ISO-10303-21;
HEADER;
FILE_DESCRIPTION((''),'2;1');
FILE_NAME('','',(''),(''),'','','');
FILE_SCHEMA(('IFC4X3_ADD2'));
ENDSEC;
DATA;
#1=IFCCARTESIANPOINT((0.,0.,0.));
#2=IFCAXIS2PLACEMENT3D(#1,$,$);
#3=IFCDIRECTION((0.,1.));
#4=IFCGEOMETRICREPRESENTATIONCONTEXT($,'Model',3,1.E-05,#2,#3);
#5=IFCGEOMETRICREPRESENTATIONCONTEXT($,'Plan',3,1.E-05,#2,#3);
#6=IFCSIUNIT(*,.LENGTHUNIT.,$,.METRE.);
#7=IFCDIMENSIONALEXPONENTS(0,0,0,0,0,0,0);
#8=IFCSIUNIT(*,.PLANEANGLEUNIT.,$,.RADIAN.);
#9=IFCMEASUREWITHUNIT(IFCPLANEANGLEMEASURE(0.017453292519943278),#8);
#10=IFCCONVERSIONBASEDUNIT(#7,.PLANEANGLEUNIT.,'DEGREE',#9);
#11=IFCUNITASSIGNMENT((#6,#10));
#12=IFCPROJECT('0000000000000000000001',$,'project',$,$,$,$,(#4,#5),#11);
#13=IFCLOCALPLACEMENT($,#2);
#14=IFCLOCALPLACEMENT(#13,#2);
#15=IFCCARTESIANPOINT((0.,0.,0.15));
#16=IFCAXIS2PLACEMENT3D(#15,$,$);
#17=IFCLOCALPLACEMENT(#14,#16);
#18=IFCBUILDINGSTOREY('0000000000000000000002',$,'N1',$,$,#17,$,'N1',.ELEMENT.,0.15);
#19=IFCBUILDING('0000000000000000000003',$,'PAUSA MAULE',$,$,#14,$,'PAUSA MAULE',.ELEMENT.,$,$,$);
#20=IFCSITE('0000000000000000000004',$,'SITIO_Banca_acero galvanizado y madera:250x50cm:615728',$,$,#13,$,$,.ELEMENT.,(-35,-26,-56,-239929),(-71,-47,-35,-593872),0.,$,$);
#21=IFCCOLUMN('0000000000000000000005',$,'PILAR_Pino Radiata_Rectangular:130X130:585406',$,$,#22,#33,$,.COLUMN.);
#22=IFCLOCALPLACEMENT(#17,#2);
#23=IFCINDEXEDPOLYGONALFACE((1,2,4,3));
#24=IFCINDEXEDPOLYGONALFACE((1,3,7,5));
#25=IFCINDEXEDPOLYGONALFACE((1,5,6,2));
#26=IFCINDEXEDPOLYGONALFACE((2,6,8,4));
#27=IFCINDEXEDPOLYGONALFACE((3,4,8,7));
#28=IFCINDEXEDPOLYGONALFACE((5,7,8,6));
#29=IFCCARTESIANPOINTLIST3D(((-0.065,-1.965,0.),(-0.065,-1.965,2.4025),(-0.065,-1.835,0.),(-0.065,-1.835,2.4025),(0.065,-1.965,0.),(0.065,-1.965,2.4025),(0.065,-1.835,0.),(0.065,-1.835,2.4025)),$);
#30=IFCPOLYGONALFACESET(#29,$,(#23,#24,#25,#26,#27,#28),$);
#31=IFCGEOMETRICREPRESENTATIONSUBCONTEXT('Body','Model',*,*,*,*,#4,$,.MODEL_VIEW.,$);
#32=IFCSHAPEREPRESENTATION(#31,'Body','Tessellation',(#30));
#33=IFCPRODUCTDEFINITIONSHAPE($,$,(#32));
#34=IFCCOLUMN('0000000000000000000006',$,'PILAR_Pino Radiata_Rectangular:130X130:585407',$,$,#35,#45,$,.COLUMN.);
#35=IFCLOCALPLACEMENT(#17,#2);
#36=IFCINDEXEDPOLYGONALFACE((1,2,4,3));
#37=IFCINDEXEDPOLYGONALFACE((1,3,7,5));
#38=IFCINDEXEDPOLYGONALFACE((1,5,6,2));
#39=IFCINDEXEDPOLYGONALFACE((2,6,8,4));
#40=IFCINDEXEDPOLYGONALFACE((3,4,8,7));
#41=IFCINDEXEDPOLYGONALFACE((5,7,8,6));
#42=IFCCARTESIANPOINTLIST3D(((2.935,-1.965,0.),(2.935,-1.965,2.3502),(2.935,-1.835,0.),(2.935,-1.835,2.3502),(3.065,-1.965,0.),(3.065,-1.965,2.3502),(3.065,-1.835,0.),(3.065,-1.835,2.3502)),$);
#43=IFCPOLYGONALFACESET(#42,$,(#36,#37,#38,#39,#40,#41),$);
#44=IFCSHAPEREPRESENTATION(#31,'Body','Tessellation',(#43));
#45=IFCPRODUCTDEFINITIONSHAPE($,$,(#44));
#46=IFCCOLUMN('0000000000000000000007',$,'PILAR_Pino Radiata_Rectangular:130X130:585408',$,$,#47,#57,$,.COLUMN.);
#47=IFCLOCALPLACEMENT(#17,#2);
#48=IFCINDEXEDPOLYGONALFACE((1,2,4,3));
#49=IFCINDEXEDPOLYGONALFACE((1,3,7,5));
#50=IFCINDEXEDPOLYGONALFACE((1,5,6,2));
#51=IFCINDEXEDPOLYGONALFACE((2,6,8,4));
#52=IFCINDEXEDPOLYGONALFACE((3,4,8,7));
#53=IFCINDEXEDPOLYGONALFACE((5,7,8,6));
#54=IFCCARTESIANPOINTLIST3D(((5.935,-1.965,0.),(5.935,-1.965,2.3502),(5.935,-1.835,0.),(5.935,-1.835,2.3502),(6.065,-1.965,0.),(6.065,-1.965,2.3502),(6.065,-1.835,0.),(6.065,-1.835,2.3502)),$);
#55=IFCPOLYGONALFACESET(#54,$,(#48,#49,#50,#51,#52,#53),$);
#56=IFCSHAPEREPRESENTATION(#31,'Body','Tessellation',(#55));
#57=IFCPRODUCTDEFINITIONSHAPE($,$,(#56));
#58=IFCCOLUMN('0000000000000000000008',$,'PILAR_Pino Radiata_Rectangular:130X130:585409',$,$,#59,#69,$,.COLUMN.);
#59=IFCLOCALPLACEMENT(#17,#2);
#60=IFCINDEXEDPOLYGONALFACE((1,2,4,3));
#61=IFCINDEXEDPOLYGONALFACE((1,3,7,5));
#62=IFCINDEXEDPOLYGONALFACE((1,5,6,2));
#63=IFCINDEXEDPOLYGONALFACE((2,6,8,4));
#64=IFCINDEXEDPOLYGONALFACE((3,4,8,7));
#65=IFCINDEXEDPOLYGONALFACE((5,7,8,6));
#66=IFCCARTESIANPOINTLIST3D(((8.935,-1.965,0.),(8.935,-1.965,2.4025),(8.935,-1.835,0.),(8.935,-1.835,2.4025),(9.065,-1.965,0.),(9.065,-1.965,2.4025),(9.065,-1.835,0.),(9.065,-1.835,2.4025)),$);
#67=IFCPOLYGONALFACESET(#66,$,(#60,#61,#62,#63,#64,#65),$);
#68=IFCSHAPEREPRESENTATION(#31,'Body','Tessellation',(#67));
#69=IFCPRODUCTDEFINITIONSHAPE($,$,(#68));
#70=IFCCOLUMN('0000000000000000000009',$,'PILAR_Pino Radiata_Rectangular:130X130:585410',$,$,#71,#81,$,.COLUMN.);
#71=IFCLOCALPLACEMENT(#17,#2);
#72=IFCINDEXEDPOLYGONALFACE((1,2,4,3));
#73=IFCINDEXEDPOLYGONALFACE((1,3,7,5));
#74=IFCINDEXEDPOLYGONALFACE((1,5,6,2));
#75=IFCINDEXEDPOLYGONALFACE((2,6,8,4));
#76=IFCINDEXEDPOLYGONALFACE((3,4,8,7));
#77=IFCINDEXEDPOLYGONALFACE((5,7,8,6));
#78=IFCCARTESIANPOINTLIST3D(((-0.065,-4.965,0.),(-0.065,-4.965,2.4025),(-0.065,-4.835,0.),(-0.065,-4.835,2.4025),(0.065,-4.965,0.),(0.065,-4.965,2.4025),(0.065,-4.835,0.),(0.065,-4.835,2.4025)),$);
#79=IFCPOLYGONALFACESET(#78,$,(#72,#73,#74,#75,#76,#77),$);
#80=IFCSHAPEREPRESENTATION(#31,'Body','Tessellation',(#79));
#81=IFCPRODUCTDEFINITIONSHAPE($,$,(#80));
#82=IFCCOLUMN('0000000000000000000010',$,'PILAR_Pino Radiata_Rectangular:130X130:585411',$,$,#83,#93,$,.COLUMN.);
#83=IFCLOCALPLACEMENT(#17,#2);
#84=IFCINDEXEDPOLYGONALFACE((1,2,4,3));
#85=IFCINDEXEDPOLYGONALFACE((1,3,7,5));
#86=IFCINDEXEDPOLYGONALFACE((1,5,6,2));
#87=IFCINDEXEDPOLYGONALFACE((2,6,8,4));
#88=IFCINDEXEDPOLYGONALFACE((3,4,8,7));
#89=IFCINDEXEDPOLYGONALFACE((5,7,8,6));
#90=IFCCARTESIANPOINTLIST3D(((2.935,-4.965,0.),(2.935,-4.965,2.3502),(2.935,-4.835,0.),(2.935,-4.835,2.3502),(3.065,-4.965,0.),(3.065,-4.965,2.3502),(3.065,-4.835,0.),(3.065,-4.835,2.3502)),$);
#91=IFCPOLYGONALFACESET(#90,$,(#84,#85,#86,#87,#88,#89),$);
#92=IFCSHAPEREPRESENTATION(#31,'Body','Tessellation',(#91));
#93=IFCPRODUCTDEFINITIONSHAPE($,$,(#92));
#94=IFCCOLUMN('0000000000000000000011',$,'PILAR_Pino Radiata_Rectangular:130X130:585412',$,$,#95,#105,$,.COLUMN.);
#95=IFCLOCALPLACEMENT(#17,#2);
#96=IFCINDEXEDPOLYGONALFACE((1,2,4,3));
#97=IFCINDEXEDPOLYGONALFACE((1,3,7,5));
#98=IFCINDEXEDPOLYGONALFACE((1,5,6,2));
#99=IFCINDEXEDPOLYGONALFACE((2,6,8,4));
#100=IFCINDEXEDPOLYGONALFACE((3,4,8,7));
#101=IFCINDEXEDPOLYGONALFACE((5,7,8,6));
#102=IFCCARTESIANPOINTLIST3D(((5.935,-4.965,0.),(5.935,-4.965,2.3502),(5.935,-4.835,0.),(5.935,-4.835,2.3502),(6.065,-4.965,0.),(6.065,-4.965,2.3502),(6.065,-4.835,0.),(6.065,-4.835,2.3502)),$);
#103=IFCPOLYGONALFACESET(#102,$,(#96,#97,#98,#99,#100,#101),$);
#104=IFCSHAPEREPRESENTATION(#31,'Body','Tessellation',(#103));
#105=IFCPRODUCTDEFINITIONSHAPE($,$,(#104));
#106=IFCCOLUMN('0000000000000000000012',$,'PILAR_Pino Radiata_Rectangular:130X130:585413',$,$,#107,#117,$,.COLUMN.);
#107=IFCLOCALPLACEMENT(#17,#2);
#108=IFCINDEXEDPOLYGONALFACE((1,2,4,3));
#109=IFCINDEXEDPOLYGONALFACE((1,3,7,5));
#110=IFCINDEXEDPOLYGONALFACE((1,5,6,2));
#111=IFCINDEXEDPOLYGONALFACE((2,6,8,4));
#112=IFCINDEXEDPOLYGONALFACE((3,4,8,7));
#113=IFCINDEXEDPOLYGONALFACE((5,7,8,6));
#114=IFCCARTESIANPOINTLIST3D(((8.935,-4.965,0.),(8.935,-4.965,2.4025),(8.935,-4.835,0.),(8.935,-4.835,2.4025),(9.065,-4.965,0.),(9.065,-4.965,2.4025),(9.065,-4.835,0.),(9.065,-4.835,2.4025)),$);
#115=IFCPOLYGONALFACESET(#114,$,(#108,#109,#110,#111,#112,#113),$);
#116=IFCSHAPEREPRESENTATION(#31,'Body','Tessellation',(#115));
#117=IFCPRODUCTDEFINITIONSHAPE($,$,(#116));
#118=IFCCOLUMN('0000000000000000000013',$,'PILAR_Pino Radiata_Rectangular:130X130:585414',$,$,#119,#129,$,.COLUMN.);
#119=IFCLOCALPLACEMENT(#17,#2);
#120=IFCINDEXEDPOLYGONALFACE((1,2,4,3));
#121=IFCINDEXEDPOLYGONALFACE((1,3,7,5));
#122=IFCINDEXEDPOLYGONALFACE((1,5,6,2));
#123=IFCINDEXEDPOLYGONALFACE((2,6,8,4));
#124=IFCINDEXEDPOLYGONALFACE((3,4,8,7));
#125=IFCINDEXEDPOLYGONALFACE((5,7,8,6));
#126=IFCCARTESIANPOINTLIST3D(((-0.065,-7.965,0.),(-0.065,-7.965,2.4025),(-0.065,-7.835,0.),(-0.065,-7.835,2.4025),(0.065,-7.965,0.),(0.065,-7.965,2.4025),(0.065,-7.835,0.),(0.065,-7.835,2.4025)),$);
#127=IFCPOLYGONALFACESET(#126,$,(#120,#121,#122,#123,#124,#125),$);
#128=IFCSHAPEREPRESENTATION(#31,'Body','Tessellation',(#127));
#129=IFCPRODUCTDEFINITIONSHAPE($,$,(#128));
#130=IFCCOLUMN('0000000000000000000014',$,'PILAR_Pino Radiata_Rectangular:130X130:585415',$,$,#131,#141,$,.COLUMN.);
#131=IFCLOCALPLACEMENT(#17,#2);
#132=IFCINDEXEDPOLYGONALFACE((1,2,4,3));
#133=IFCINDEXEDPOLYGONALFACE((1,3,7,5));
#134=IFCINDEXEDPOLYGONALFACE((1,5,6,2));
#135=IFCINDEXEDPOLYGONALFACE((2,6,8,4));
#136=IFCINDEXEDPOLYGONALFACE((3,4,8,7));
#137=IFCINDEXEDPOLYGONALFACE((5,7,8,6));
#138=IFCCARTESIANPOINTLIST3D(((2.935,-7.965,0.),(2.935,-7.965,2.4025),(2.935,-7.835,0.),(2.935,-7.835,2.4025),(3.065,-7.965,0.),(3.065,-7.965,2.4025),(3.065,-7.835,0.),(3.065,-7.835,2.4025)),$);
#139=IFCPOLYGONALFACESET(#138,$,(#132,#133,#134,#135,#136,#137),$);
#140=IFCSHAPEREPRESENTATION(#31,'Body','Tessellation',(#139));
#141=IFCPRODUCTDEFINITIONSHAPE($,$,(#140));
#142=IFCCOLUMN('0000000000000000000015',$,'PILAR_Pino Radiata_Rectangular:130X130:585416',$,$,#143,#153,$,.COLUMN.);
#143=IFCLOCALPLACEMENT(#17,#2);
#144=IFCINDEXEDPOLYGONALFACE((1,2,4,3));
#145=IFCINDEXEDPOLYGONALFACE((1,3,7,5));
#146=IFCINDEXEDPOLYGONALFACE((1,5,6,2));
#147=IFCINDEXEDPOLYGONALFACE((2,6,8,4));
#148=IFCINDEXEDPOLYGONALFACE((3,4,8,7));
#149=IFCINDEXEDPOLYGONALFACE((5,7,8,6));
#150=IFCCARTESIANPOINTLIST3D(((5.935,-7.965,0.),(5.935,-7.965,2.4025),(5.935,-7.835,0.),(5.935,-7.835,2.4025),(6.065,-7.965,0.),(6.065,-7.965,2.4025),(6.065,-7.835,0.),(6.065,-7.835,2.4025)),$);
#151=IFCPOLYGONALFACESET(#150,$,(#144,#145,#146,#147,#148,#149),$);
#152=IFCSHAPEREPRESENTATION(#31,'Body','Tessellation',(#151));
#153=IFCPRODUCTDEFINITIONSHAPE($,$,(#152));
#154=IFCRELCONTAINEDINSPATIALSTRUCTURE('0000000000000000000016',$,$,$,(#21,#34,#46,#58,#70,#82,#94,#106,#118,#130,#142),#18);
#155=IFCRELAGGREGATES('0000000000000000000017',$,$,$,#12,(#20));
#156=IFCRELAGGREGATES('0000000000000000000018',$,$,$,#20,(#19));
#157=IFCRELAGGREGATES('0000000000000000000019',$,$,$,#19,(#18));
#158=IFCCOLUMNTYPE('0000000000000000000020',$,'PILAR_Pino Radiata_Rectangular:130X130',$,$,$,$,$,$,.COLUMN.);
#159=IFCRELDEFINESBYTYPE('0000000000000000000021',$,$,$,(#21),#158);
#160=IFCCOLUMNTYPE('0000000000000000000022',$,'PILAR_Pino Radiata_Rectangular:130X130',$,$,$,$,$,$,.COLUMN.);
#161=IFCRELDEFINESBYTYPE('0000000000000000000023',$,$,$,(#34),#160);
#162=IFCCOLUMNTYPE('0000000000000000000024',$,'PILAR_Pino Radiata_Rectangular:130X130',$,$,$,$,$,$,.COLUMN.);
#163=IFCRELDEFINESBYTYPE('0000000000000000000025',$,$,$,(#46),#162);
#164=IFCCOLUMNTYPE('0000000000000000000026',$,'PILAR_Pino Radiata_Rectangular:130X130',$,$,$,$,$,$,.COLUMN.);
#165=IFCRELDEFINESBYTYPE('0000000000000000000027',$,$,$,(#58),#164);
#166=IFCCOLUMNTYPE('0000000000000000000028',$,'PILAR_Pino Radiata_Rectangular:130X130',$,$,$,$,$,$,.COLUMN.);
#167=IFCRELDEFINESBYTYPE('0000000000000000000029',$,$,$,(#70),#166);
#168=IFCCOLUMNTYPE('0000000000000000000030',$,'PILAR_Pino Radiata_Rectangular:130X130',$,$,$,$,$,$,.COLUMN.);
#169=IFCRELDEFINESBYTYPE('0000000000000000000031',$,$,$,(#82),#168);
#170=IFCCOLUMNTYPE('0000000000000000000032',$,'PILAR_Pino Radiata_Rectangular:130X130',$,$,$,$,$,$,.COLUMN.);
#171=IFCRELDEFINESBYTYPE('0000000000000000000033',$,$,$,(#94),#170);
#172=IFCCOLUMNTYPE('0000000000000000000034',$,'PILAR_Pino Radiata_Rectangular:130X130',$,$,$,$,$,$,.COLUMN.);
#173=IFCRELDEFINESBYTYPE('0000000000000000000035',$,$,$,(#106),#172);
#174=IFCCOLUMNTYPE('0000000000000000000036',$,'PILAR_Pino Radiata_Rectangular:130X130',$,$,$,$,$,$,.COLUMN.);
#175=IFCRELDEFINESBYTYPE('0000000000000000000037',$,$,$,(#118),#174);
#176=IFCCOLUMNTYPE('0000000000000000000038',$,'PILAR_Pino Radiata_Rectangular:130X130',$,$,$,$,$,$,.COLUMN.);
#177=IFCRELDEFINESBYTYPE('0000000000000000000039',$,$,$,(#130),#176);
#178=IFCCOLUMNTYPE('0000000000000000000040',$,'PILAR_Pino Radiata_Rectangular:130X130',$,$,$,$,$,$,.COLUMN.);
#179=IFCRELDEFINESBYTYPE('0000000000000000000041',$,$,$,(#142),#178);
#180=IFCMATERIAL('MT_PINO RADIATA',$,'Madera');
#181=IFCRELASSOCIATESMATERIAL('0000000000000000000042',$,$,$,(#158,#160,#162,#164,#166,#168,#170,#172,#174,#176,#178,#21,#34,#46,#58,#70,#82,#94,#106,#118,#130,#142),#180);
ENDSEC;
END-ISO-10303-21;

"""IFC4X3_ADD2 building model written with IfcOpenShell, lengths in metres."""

from ifc_helpers import new_model, entity, si_unit, converted_unit, direction, frame, frame_2d, origin, origin_2d_with_axis, place, context, subcontext, project, spatial, rectangle, extrude, source, transform, mapped, material, material_profile, profile_set, profile_usage, type_object, type_shapes, element, save


model = new_model("IFC4X3_ADD2")

# Units and contexts
model_context = context("Model", 3, precision=1e-05, world=origin(), true_north=direction((0.0, 1.0)))
plan_context = context("Plan", 3, precision=1e-05, world=origin(), true_north=direction((0.0, 1.0)))
body_context = subcontext(model_context, "Body", "Model", "MODEL_VIEW")
ifc_project = project(units=[si_unit("LENGTHUNIT", "METRE"), converted_unit("PLANEANGLEUNIT", "DEGREE", entity("IfcPlaneAngleMeasure", 0.017453292519943278), si_unit("PLANEANGLEUNIT", "RADIAN"), dimensions=[0, 0, 0, 0, 0, 0, 0])], contexts=[model_context, plan_context])

# Site, building, storey
site_placement = place(None, origin())
site = spatial("IfcSite", under=ifc_project, at=site_placement, Name="SITIO_Banca_acero galvanizado y madera:250x50cm:615728", CompositionType="ELEMENT", RefLatitude=(-35, -26, -56, -239929), RefLongitude=(-71, -47, -35, -593872), RefElevation=0.0)
building_placement = place(site_placement, origin())
building = spatial("IfcBuilding", under=site, at=building_placement, Name="PAUSA MAULE", LongName="PAUSA MAULE", CompositionType="ELEMENT")
storey_placement = place(building_placement, frame((0.0, 0.0, 0.15)))
storey = spatial("IfcBuildingStorey", under=building, at=storey_placement, Name="N1", LongName="N1", CompositionType="ELEMENT", Elevation=0.15)

# Columns
ifc_material_1 = material(Name="MT_PINO RADIATA", Category="Madera")
ifc_material_profile = material_profile(ifc_material_1, rectangle(XDim=0.13, YDim=0.13, at=frame_2d((0.0, 0.0), x_axis=(1.0, 0.0))), Name="130X130")
ifc_profile_set = profile_set([ifc_material_profile], Name="130X130")
ifc_profile_usage = profile_usage(ifc_profile_set)
column_type_1 = type_object("IfcColumnType", Name="PILAR_Pino Radiata_Rectangular:130X130", PredefinedType="COLUMN", material=ifc_profile_set)
shared_shape_1 = source(origin(), body_context, "Body", "SweptSolid", [
    extrude(rectangle(XDim=0.13, YDim=0.13, at=frame_2d((0.0, 0.0), x_axis=(1.0, 0.0))), frame((0.0, -1.9, 0.15)), (0.0, 0.0, 1.0), 2.4025),
])
type_shapes(column_type_1, [shared_shape_1])
column_1_placement = place(storey_placement, frame((0.0, 0.0, -0.15)))
element("IfcColumn", 1, at=column_1_placement, inside=storey, type_object=column_type_1, material=ifc_profile_usage, Name="PILAR_Pino Radiata_Rectangular:130X130:585406", PredefinedType="COLUMN", context=body_context, shape_type="MappedRepresentation", body=[
    mapped(shared_shape_1, transform((0.0, 0.0, 0.0), scale=1.0)),
])
column_type_2 = type_object("IfcColumnType", Name="PILAR_Pino Radiata_Rectangular:130X130", PredefinedType="COLUMN", material=ifc_profile_set)
shared_shape_2 = source(origin(), body_context, "Body", "SweptSolid", [
    extrude(rectangle(XDim=0.13, YDim=0.13, at=frame_2d((0.0, 0.0), x_axis=(1.0, 0.0))), frame((3.0, -1.9, 0.15)), (0.0, 0.0, 1.0), 2.3502),
])
type_shapes(column_type_2, [shared_shape_2])
column_2_placement = place(storey_placement, frame((0.0, 0.0, -0.15)))
element("IfcColumn", 2, at=column_2_placement, inside=storey, type_object=column_type_2, material=ifc_profile_usage, Name="PILAR_Pino Radiata_Rectangular:130X130:585407", PredefinedType="COLUMN", context=body_context, shape_type="MappedRepresentation", body=[
    mapped(shared_shape_2, transform((0.0, 0.0, 0.0), scale=1.0)),
])
column_type_3 = type_object("IfcColumnType", Name="PILAR_Pino Radiata_Rectangular:130X130", PredefinedType="COLUMN", material=ifc_profile_set)
shared_shape_3 = source(origin(), body_context, "Body", "SweptSolid", [
    extrude(rectangle(XDim=0.13, YDim=0.13, at=frame_2d((0.0, 0.0), x_axis=(1.0, 0.0))), frame((6.0, -1.9, 0.15)), (0.0, 0.0, 1.0), 2.3502),
])
type_shapes(column_type_3, [shared_shape_3])
column_3_placement = place(storey_placement, frame((0.0, 0.0, -0.15)))
element("IfcColumn", 3, at=column_3_placement, inside=storey, type_object=column_type_3, material=ifc_profile_usage, Name="PILAR_Pino Radiata_Rectangular:130X130:585408", PredefinedType="COLUMN", context=body_context, shape_type="MappedRepresentation", body=[
    mapped(shared_shape_3, transform((0.0, 0.0, 0.0), scale=1.0)),
])
column_type_4 = type_object("IfcColumnType", Name="PILAR_Pino Radiata_Rectangular:130X130", PredefinedType="COLUMN", material=ifc_profile_set)
shared_shape_4 = source(origin(), body_context, "Body", "SweptSolid", [
    extrude(rectangle(XDim=0.13, YDim=0.13, at=frame_2d((0.0, 0.0), x_axis=(1.0, 0.0))), frame((9.0, -1.9, 0.15)), (0.0, 0.0, 1.0), 2.4025),
])
type_shapes(column_type_4, [shared_shape_4])
column_4_placement = place(storey_placement, frame((0.0, 0.0, -0.15)))
element("IfcColumn", 4, at=column_4_placement, inside=storey, type_object=column_type_4, material=ifc_profile_usage, Name="PILAR_Pino Radiata_Rectangular:130X130:585409", PredefinedType="COLUMN", context=body_context, shape_type="MappedRepresentation", body=[
    mapped(shared_shape_4, transform((0.0, 0.0, 0.0), scale=1.0)),
])
column_type_5 = type_object("IfcColumnType", Name="PILAR_Pino Radiata_Rectangular:130X130", PredefinedType="COLUMN", material=ifc_profile_set)
shared_shape_5 = source(origin(), body_context, "Body", "SweptSolid", [
    extrude(rectangle(XDim=0.13, YDim=0.13, at=frame_2d((0.0, 0.0), x_axis=(1.0, 0.0))), frame((0.0, -4.9, 0.15)), (0.0, 0.0, 1.0), 2.4025),
])
type_shapes(column_type_5, [shared_shape_5])
column_5_placement = place(storey_placement, frame((0.0, 0.0, -0.15)))
element("IfcColumn", 5, at=column_5_placement, inside=storey, type_object=column_type_5, material=ifc_profile_usage, Name="PILAR_Pino Radiata_Rectangular:130X130:585410", PredefinedType="COLUMN", context=body_context, shape_type="MappedRepresentation", body=[
    mapped(shared_shape_5, transform((0.0, 0.0, 0.0), scale=1.0)),
])
column_type_6 = type_object("IfcColumnType", Name="PILAR_Pino Radiata_Rectangular:130X130", PredefinedType="COLUMN", material=ifc_profile_set)
shared_shape_6 = source(origin(), body_context, "Body", "SweptSolid", [
    extrude(rectangle(XDim=0.13, YDim=0.13, at=frame_2d((0.0, 0.0), x_axis=(1.0, 0.0))), frame((3.0, -4.9, 0.15)), (0.0, 0.0, 1.0), 2.3502),
])
type_shapes(column_type_6, [shared_shape_6])
column_6_placement = place(storey_placement, frame((0.0, 0.0, -0.15)))
element("IfcColumn", 6, at=column_6_placement, inside=storey, type_object=column_type_6, material=ifc_profile_usage, Name="PILAR_Pino Radiata_Rectangular:130X130:585411", PredefinedType="COLUMN", context=body_context, shape_type="MappedRepresentation", body=[
    mapped(shared_shape_6, transform((0.0, 0.0, 0.0), scale=1.0)),
])
column_type_7 = type_object("IfcColumnType", Name="PILAR_Pino Radiata_Rectangular:130X130", PredefinedType="COLUMN", material=ifc_profile_set)
shared_shape_7 = source(origin(), body_context, "Body", "SweptSolid", [
    extrude(rectangle(XDim=0.13, YDim=0.13, at=frame_2d((0.0, 0.0), x_axis=(1.0, 0.0))), frame((6.0, -4.9, 0.15)), (0.0, 0.0, 1.0), 2.3502),
])
type_shapes(column_type_7, [shared_shape_7])
column_7_placement = place(storey_placement, frame((0.0, 0.0, -0.15)))
element("IfcColumn", 7, at=column_7_placement, inside=storey, type_object=column_type_7, material=ifc_profile_usage, Name="PILAR_Pino Radiata_Rectangular:130X130:585412", PredefinedType="COLUMN", context=body_context, shape_type="MappedRepresentation", body=[
    mapped(shared_shape_7, transform((0.0, 0.0, 0.0), scale=1.0)),
])
column_type_8 = type_object("IfcColumnType", Name="PILAR_Pino Radiata_Rectangular:130X130", PredefinedType="COLUMN", material=ifc_profile_set)
shared_shape_8 = source(origin(), body_context, "Body", "SweptSolid", [
    extrude(rectangle(XDim=0.13, YDim=0.13, at=frame_2d((0.0, 0.0), x_axis=(1.0, 0.0))), frame((9.0, -4.9, 0.15)), (0.0, 0.0, 1.0), 2.4025),
])
type_shapes(column_type_8, [shared_shape_8])
column_8_placement = place(storey_placement, frame((0.0, 0.0, -0.15)))
element("IfcColumn", 8, at=column_8_placement, inside=storey, type_object=column_type_8, material=ifc_profile_usage, Name="PILAR_Pino Radiata_Rectangular:130X130:585413", PredefinedType="COLUMN", context=body_context, shape_type="MappedRepresentation", body=[
    mapped(shared_shape_8, transform((0.0, 0.0, 0.0), scale=1.0)),
])
column_type_9 = type_object("IfcColumnType", Name="PILAR_Pino Radiata_Rectangular:130X130", PredefinedType="COLUMN", material=ifc_profile_set)
shared_shape_9 = source(origin(), body_context, "Body", "SweptSolid", [
    extrude(rectangle(XDim=0.13, YDim=0.13, at=frame_2d((0.0, 0.0), x_axis=(1.0, 0.0))), frame((0.0, -7.9, 0.15)), (0.0, 0.0, 1.0), 2.4025),
])
type_shapes(column_type_9, [shared_shape_9])
column_9_placement = place(storey_placement, frame((0.0, 0.0, -0.15)))
element("IfcColumn", 9, at=column_9_placement, inside=storey, type_object=column_type_9, material=ifc_profile_usage, Name="PILAR_Pino Radiata_Rectangular:130X130:585414", PredefinedType="COLUMN", context=body_context, shape_type="MappedRepresentation", body=[
    mapped(shared_shape_9, transform((0.0, 0.0, 0.0), scale=1.0)),
])
column_type_10 = type_object("IfcColumnType", Name="PILAR_Pino Radiata_Rectangular:130X130", PredefinedType="COLUMN", material=ifc_profile_set)
shared_shape_10 = source(origin(), body_context, "Body", "SweptSolid", [
    extrude(rectangle(XDim=0.13, YDim=0.13, at=frame_2d((0.0, 0.0), x_axis=(1.0, 0.0))), frame((3.0, -7.9, 0.15)), (0.0, 0.0, 1.0), 2.4025),
])
type_shapes(column_type_10, [shared_shape_10])
column_10_placement = place(storey_placement, frame((0.0, 0.0, -0.15)))
element("IfcColumn", 10, at=column_10_placement, inside=storey, type_object=column_type_10, material=ifc_profile_usage, Name="PILAR_Pino Radiata_Rectangular:130X130:585415", PredefinedType="COLUMN", context=body_context, shape_type="MappedRepresentation", body=[
    mapped(shared_shape_10, transform((0.0, 0.0, 0.0), scale=1.0)),
])
column_type_11 = type_object("IfcColumnType", Name="PILAR_Pino Radiata_Rectangular:130X130", PredefinedType="COLUMN", material=ifc_profile_set)
shared_shape_11 = source(origin(), body_context, "Body", "SweptSolid", [
    extrude(rectangle(XDim=0.13, YDim=0.13, at=origin_2d_with_axis()), frame((0.0, 0.0, 0.15), z_axis=(0.0, 0.0, 1.0), x_axis=(-1.0, 0.0, 0.0)), (0.0, 0.0, 1.0), 2.4025),
])
type_shapes(column_type_11, [shared_shape_11])
column_11_placement = place(storey_placement, frame((6.0, -7.9, -0.15), z_axis=(0.0, 0.0, 1.0), x_axis=(-1.0, 0.0, 0.0)))
element("IfcColumn", 11, at=column_11_placement, inside=storey, type_object=column_type_11, material=ifc_profile_usage, Name="PILAR_Pino Radiata_Rectangular:130X130:585416", PredefinedType="COLUMN", context=body_context, shape_type="MappedRepresentation", body=[
    mapped(shared_shape_11, transform((0.0, 0.0, 0.0), scale=1.0)),
])

save(model, "model.ifc")
